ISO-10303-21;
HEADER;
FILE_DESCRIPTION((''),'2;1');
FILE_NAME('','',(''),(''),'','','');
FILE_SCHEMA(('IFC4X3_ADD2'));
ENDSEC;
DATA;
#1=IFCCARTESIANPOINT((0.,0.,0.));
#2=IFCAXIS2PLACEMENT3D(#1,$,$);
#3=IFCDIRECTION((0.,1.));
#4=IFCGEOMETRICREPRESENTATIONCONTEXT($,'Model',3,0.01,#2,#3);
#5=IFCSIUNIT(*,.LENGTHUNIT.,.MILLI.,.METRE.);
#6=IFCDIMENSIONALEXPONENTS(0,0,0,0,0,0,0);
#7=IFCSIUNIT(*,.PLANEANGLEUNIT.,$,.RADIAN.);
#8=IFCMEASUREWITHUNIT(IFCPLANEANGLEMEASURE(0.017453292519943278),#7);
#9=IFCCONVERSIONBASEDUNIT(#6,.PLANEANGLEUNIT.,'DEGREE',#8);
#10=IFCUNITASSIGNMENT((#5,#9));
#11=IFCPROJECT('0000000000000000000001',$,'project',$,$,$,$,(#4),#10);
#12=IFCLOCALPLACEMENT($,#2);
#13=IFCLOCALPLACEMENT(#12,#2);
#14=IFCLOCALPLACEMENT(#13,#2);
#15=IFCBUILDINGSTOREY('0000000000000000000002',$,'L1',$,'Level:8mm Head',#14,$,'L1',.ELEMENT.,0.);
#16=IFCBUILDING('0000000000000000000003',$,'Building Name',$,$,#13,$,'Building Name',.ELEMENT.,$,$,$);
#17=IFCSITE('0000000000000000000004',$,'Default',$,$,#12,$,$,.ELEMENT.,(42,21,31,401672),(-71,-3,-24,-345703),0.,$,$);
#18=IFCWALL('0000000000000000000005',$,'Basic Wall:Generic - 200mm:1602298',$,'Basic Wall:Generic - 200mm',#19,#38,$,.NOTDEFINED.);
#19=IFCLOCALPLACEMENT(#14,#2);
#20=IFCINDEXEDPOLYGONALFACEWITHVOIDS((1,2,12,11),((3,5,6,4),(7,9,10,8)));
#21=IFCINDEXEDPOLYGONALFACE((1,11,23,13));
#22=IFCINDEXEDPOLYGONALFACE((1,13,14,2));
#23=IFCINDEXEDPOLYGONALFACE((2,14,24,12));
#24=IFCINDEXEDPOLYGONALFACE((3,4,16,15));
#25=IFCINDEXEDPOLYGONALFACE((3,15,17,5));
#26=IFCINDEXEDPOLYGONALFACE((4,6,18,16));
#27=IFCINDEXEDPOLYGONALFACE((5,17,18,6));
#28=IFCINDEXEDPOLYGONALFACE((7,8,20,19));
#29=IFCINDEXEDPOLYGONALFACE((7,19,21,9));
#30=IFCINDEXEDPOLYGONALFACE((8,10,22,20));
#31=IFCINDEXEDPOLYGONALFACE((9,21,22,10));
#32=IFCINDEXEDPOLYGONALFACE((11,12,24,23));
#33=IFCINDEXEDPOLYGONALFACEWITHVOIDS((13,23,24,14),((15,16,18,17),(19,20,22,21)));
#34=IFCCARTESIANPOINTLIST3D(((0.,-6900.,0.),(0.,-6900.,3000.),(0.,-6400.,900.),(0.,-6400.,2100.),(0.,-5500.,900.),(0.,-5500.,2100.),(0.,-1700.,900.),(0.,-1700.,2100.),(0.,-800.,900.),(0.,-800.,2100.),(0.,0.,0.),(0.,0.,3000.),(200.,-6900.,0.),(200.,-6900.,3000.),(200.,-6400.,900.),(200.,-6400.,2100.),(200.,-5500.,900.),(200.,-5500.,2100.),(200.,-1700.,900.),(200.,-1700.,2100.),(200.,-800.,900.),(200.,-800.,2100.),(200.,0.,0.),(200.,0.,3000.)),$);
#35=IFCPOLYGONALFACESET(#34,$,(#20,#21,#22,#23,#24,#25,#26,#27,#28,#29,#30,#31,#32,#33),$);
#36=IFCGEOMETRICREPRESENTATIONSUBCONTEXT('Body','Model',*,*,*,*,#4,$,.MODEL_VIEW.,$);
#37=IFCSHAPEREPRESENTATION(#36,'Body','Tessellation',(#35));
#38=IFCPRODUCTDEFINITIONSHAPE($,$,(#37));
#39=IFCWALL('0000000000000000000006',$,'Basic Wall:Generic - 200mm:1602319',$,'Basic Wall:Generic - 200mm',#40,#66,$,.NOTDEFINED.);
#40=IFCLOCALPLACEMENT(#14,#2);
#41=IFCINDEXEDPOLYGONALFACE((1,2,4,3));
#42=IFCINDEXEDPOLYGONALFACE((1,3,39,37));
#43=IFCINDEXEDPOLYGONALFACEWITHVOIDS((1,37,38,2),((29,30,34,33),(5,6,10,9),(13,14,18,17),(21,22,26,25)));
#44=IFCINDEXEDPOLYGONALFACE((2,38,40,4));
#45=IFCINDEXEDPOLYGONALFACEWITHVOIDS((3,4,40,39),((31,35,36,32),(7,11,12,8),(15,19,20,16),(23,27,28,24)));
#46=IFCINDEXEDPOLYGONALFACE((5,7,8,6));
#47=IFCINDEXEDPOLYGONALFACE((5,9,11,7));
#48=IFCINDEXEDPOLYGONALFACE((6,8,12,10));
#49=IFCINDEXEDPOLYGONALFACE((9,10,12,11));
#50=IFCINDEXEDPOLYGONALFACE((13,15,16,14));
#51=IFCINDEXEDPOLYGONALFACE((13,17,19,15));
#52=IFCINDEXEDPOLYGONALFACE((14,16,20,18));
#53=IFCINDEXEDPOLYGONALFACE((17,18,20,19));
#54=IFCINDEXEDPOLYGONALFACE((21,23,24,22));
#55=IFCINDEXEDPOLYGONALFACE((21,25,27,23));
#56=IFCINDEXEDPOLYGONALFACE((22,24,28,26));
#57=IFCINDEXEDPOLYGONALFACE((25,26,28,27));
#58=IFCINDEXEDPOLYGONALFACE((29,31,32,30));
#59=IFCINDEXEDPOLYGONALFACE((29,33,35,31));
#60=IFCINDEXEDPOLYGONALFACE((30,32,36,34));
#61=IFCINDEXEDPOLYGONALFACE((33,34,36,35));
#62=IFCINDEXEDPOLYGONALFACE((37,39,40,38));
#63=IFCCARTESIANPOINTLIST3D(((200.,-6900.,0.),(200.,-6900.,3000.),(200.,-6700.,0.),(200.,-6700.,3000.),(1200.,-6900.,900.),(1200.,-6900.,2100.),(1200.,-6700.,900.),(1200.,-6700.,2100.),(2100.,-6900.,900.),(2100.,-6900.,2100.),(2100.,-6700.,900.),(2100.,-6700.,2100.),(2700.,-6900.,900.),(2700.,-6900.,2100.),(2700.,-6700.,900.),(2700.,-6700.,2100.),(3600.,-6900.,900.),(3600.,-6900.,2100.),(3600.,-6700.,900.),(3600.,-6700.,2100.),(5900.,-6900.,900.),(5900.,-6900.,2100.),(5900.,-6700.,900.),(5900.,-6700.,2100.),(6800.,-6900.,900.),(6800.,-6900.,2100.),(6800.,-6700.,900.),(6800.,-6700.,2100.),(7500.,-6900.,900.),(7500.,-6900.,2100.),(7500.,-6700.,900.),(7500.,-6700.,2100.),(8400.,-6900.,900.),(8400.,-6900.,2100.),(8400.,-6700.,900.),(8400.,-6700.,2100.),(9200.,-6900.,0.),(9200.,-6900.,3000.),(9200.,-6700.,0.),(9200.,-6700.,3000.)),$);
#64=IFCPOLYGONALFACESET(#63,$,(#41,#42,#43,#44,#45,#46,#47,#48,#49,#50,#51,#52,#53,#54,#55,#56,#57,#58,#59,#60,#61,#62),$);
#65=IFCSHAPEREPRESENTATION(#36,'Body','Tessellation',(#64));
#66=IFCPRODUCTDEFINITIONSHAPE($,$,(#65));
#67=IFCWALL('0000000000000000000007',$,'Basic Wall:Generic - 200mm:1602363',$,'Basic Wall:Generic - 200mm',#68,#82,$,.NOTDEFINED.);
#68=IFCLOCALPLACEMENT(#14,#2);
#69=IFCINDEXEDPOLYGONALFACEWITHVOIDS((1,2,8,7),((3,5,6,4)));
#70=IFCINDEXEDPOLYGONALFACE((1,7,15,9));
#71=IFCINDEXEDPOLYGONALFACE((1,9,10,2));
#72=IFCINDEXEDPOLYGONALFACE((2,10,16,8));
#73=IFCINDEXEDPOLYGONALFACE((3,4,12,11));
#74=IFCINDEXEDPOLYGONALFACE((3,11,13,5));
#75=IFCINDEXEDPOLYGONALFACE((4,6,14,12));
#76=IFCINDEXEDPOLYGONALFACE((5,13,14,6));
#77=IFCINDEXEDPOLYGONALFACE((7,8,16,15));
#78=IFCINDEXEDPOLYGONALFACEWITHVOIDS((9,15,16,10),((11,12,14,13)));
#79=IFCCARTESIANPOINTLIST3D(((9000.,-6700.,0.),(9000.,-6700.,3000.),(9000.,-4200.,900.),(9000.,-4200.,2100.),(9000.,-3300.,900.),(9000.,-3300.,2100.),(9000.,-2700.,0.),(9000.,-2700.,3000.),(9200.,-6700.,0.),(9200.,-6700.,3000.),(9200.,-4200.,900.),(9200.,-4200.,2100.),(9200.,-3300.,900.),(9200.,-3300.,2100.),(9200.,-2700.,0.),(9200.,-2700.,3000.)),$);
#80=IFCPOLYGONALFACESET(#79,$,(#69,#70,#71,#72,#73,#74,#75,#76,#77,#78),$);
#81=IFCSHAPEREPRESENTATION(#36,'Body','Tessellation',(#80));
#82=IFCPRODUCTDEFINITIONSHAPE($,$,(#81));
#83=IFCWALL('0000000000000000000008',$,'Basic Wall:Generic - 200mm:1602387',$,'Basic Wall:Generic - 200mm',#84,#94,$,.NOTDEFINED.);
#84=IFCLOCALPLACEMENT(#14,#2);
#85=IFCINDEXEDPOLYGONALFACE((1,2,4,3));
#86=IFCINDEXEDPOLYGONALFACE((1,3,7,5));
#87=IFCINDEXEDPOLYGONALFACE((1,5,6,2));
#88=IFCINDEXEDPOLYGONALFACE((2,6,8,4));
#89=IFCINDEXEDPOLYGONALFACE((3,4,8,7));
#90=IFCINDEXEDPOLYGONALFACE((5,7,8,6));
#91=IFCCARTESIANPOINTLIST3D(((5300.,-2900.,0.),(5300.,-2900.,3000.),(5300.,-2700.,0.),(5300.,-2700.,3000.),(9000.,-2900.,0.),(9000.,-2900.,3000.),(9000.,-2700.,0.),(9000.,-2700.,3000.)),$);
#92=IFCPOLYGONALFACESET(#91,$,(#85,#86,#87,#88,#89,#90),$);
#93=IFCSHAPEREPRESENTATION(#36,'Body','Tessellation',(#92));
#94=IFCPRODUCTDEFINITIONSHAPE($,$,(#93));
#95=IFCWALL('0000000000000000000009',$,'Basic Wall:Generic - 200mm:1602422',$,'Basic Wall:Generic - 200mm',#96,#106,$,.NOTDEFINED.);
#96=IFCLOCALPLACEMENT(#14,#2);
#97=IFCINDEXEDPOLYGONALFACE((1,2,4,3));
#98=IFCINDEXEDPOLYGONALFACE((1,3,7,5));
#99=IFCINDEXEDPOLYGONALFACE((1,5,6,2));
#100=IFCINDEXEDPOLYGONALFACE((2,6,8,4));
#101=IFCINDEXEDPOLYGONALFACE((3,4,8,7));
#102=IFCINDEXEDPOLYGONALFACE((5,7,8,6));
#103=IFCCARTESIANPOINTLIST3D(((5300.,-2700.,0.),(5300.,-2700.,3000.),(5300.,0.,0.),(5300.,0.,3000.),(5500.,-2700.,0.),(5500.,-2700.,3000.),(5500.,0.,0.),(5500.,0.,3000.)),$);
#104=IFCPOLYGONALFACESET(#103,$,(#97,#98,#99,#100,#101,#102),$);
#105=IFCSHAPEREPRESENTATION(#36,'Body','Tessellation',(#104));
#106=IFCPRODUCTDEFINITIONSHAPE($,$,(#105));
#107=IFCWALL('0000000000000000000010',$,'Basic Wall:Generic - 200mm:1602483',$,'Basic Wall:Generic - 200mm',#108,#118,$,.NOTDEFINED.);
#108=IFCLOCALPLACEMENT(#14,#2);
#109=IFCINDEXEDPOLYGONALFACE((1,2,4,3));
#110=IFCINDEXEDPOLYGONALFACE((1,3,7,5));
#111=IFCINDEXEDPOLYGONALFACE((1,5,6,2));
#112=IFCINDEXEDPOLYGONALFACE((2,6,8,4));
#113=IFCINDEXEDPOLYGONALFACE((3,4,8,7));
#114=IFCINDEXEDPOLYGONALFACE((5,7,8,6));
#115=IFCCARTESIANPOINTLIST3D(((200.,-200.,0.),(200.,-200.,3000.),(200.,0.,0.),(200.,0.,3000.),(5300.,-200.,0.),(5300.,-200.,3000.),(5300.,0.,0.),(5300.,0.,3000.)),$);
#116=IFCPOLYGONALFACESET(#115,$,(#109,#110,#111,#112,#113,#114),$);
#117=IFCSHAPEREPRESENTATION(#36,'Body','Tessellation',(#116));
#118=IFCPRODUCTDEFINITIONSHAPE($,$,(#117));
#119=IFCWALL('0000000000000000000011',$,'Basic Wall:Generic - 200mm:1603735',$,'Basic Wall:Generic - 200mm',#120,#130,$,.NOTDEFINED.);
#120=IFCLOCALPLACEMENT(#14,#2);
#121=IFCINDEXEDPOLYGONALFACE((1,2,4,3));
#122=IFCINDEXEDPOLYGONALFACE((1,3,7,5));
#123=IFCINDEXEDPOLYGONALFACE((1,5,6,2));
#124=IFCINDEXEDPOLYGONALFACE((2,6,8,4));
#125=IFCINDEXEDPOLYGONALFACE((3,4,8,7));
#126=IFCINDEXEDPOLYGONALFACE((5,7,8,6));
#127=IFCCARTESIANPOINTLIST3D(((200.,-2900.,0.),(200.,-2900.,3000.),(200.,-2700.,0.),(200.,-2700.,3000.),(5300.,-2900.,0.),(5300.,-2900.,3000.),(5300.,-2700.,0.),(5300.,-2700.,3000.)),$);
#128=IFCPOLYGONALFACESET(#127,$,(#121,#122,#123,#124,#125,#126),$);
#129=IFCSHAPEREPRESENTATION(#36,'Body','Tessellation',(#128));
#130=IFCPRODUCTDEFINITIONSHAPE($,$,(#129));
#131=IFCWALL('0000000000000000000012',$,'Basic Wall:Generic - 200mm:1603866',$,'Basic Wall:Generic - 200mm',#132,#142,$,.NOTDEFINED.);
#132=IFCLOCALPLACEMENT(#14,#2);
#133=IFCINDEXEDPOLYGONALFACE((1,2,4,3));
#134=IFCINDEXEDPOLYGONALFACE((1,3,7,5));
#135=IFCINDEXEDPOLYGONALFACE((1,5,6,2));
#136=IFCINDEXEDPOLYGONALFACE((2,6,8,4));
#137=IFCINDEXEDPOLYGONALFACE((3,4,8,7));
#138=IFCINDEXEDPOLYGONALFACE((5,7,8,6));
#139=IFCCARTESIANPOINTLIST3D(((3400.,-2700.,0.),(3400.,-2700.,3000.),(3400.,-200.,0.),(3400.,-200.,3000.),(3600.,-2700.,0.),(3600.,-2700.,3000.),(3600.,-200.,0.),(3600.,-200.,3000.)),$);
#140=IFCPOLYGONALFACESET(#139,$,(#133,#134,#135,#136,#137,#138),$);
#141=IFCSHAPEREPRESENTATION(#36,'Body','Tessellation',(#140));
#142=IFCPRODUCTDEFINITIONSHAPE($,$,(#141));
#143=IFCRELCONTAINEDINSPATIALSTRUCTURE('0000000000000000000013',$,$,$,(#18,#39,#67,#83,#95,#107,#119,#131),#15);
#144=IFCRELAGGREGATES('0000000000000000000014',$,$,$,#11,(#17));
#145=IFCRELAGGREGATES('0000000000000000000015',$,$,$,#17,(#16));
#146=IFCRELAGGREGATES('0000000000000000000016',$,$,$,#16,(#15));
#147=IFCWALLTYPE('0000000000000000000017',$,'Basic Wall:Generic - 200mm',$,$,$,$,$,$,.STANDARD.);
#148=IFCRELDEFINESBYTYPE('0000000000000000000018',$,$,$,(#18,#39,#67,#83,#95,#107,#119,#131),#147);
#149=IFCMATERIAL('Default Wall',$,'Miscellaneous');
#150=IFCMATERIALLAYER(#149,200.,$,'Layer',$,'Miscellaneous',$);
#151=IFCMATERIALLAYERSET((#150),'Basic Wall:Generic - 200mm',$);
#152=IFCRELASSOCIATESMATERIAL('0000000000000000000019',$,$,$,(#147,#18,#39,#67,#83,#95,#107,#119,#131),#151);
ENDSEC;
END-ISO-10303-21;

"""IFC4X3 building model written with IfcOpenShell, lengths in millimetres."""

from ifc_helpers import new_model, entity, si_unit, converted_unit, direction, frame, frame_2d, origin, place, context, subcontext, project, spatial, rectangle, extrude, material, layer, layer_set, type_object, element, save


model = new_model("IFC4X3")

# Units and contexts
model_context = context("Model", 3, precision=0.01, world=origin(), true_north=direction((0.0, 1.0)))
body_context = subcontext(model_context, "Body", "Model", "MODEL_VIEW")
ifc_project = project(units=[si_unit("LENGTHUNIT", "METRE", prefix="MILLI"), converted_unit("PLANEANGLEUNIT", "DEGREE", entity("IfcPlaneAngleMeasure", 0.017453292519943278), si_unit("PLANEANGLEUNIT", "RADIAN"), dimensions=[0, 0, 0, 0, 0, 0, 0])], contexts=[model_context])

# Site, building, storey
site_placement = place(None, origin())
site = spatial("IfcSite", under=ifc_project, at=site_placement, Name="Default", CompositionType="ELEMENT", RefLatitude=(42, 21, 31, 401672), RefLongitude=(-71, -3, -24, -345703), RefElevation=0.0)
building_placement = place(site_placement, origin())
building = spatial("IfcBuilding", under=site, at=building_placement, Name="Building Name", LongName="Building Name", CompositionType="ELEMENT")
storey_placement = place(building_placement, origin())
storey = spatial("IfcBuildingStorey", under=building, at=storey_placement, Name="L1", ObjectType="Level:8mm Head", LongName="L1", CompositionType="ELEMENT", Elevation=0.0)

# Walls, openings
ifc_material_1 = material(Name="Default Wall", Category="Miscellaneous")
ifc_layer = layer(ifc_material_1, 200.0, Name="Layer", Category="Miscellaneous")
ifc_layer_set = layer_set([ifc_layer], Name="Basic Wall:Generic - 200mm")
wall_type = type_object("IfcWallType", Name="Basic Wall:Generic - 200mm", PredefinedType="STANDARD", material=ifc_layer_set)
wall_1_placement = place(storey_placement, frame((100.0, 0.0, 0.0), z_axis=(0.0, 0.0, 1.0), x_axis=(0.0, -1.0, 0.0)))
wall_1 = element("IfcWall", 1, at=wall_1_placement, inside=storey, type_object=wall_type, material=ifc_layer_set, Name="Basic Wall:Generic - 200mm:1602298", ObjectType="Basic Wall:Generic - 200mm", PredefinedType="NOTDEFINED", context=body_context, shape_type="SweptSolid", body=[
    extrude(rectangle(XDim=6900.0, YDim=200.0, at=frame_2d((3450.0, 0.0), x_axis=(-1.0, 0.0))), origin(), (0.0, 0.0, 1.0), 3000.0),
])
opening_1_placement = place(wall_1_placement, frame((1700.0, 100.0, 900.0)))
element("IfcOpeningElement", 2, at=opening_1_placement, cuts=wall_1, PredefinedType="OPENING", context=body_context, shape_type="SweptSolid", body=[
    extrude(rectangle(XDim=1200.0, YDim=900.0, at=frame_2d((600.0, 450.0), x_axis=(-1.0, 0.0))), frame((0.0, 0.0, 0.0), z_axis=(0.0, -1.0, 0.0), x_axis=(0.0, 0.0, 1.0)), (0.0, 0.0, 1.0), 200.0),
])
opening_2_placement = place(wall_1_placement, frame((6400.0, 100.0, 900.0)))
element("IfcOpeningElement", 3, at=opening_2_placement, cuts=wall_1, PredefinedType="OPENING", context=body_context, shape_type="SweptSolid", body=[
    extrude(rectangle(XDim=1200.0, YDim=900.0, at=frame_2d((600.0, 450.0), x_axis=(-1.0, 0.0))), frame((0.0, 0.0, 0.0), z_axis=(0.0, -1.0, 0.0), x_axis=(0.0, 0.0, 1.0)), (0.0, 0.0, 1.0), 200.0),
])
wall_2_placement = place(storey_placement, frame((200.0, -6800.0, 0.0)))
wall_2 = element("IfcWall", 4, at=wall_2_placement, inside=storey, type_object=wall_type, material=ifc_layer_set, Name="Basic Wall:Generic - 200mm:1602319", ObjectType="Basic Wall:Generic - 200mm", PredefinedType="NOTDEFINED", context=body_context, shape_type="SweptSolid", body=[
    extrude(rectangle(XDim=9000.0, YDim=200.0, at=frame_2d((4500.0, 0.0), x_axis=(-1.0, 0.0))), origin(), (0.0, 0.0, 1.0), 3000.0),
])
opening_3_placement = place(wall_2_placement, frame((1900.0, 100.0, 900.0)))
element("IfcOpeningElement", 5, at=opening_3_placement, cuts=wall_2, PredefinedType="OPENING", context=body_context, shape_type="SweptSolid", body=[
    extrude(rectangle(XDim=1200.0, YDim=900.0, at=frame_2d((600.0, 450.0), x_axis=(-1.0, 0.0))), frame((0.0, 0.0, 0.0), z_axis=(0.0, -1.0, 0.0), x_axis=(0.0, 0.0, 1.0)), (0.0, 0.0, 1.0), 200.0),
])
opening_4_placement = place(wall_2_placement, frame((3400.0, 100.0, 900.0)))
element("IfcOpeningElement", 6, at=opening_4_placement, cuts=wall_2, PredefinedType="OPENING", context=body_context, shape_type="SweptSolid", body=[
    extrude(rectangle(XDim=1200.0, YDim=900.0, at=frame_2d((600.0, 450.0), x_axis=(-1.0, 0.0))), frame((0.0, 0.0, 0.0), z_axis=(0.0, -1.0, 0.0), x_axis=(0.0, 0.0, 1.0)), (0.0, 0.0, 1.0), 200.0),
])
opening_5_placement = place(wall_2_placement, frame((8200.0, 100.0, 900.0)))
element("IfcOpeningElement", 7, at=opening_5_placement, cuts=wall_2, PredefinedType="OPENING", context=body_context, shape_type="SweptSolid", body=[
    extrude(rectangle(XDim=1200.0, YDim=900.0, at=frame_2d((600.0, 450.0), x_axis=(-1.0, 0.0))), frame((0.0, 0.0, 0.0), z_axis=(0.0, -1.0, 0.0), x_axis=(0.0, 0.0, 1.0)), (0.0, 0.0, 1.0), 200.0),
])
opening_6_placement = place(wall_2_placement, frame((6600.0, 100.0, 900.0)))
element("IfcOpeningElement", 8, at=opening_6_placement, cuts=wall_2, PredefinedType="OPENING", context=body_context, shape_type="SweptSolid", body=[
    extrude(rectangle(XDim=1200.0, YDim=900.0, at=frame_2d((600.0, 450.0), x_axis=(-1.0, 0.0))), frame((0.0, 0.0, 0.0), z_axis=(0.0, -1.0, 0.0), x_axis=(0.0, 0.0, 1.0)), (0.0, 0.0, 1.0), 200.0),
])

# Wall, opening
wall_3_placement = place(storey_placement, frame((9100.0, -6700.0, 0.0), z_axis=(0.0, 0.0, 1.0), x_axis=(0.0, 1.0, 0.0)))
wall_3 = element("IfcWall", 9, at=wall_3_placement, inside=storey, type_object=wall_type, material=ifc_layer_set, Name="Basic Wall:Generic - 200mm:1602363", ObjectType="Basic Wall:Generic - 200mm", PredefinedType="NOTDEFINED", context=body_context, shape_type="SweptSolid", body=[
    extrude(rectangle(XDim=4000.0, YDim=200.0, at=frame_2d((2000.0, 0.0), x_axis=(-1.0, 0.0))), origin(), (0.0, 0.0, 1.0), 3000.0),
])
opening_7_placement = place(wall_3_placement, frame((3400.0, 100.0, 900.0)))
element("IfcOpeningElement", 10, at=opening_7_placement, cuts=wall_3, PredefinedType="OPENING", context=body_context, shape_type="SweptSolid", body=[
    extrude(rectangle(XDim=1200.0, YDim=900.0, at=frame_2d((600.0, 450.0), x_axis=(-1.0, 0.0))), frame((0.0, 0.0, 0.0), z_axis=(0.0, -1.0, 0.0), x_axis=(0.0, 0.0, 1.0)), (0.0, 0.0, 1.0), 200.0),
])

# Walls
wall_4_placement = place(storey_placement, frame((9000.0, -2800.0, 0.0), z_axis=(0.0, 0.0, 1.0), x_axis=(-1.0, 0.0, 0.0)))
element("IfcWall", 11, at=wall_4_placement, inside=storey, type_object=wall_type, material=ifc_layer_set, Name="Basic Wall:Generic - 200mm:1602387", ObjectType="Basic Wall:Generic - 200mm", PredefinedType="NOTDEFINED", context=body_context, shape_type="SweptSolid", body=[
    extrude(rectangle(XDim=3700.0, YDim=200.0, at=frame_2d((1850.0, 0.0), x_axis=(-1.0, 0.0))), origin(), (0.0, 0.0, 1.0), 3000.0),
])
wall_5_placement = place(storey_placement, frame((5400.0, -2700.0, 0.0), z_axis=(0.0, 0.0, 1.0), x_axis=(0.0, 1.0, 0.0)))
element("IfcWall", 12, at=wall_5_placement, inside=storey, type_object=wall_type, material=ifc_layer_set, Name="Basic Wall:Generic - 200mm:1602422", ObjectType="Basic Wall:Generic - 200mm", PredefinedType="NOTDEFINED", context=body_context, shape_type="SweptSolid", body=[
    extrude(rectangle(XDim=2700.0, YDim=200.0, at=frame_2d((1350.0, 0.0), x_axis=(-1.0, 0.0))), origin(), (0.0, 0.0, 1.0), 3000.0),
])
wall_6_placement = place(storey_placement, frame((5300.0, -100.0, 0.0), z_axis=(0.0, 0.0, 1.0), x_axis=(-1.0, 0.0, 0.0)))
element("IfcWall", 13, at=wall_6_placement, inside=storey, type_object=wall_type, material=ifc_layer_set, Name="Basic Wall:Generic - 200mm:1602483", ObjectType="Basic Wall:Generic - 200mm", PredefinedType="NOTDEFINED", context=body_context, shape_type="SweptSolid", body=[
    extrude(rectangle(XDim=5100.0, YDim=200.0, at=frame_2d((2550.0, 0.0), x_axis=(-1.0, 0.0))), origin(), (0.0, 0.0, 1.0), 3000.0),
])
wall_7_placement = place(storey_placement, frame((200.0, -2800.0, 0.0)))
element("IfcWall", 14, at=wall_7_placement, inside=storey, type_object=wall_type, material=ifc_layer_set, Name="Basic Wall:Generic - 200mm:1603735", ObjectType="Basic Wall:Generic - 200mm", PredefinedType="NOTDEFINED", context=body_context, shape_type="SweptSolid", body=[
    extrude(rectangle(XDim=5100.0, YDim=200.0, at=frame_2d((2550.0, 0.0), x_axis=(-1.0, 0.0))), origin(), (0.0, 0.0, 1.0), 3000.0),
])
wall_8_placement = place(storey_placement, frame((3500.0, -2700.0, 0.0), z_axis=(0.0, 0.0, 1.0), x_axis=(0.0, 1.0, 0.0)))
element("IfcWall", 15, at=wall_8_placement, inside=storey, type_object=wall_type, material=ifc_layer_set, Name="Basic Wall:Generic - 200mm:1603866", ObjectType="Basic Wall:Generic - 200mm", PredefinedType="NOTDEFINED", context=body_context, shape_type="SweptSolid", body=[
    extrude(rectangle(XDim=2500.0, YDim=200.0, at=frame_2d((1250.0, 0.0), x_axis=(-1.0, 0.0))), origin(), (0.0, 0.0, 1.0), 3000.0),
])

save(model, "model.ifc")
